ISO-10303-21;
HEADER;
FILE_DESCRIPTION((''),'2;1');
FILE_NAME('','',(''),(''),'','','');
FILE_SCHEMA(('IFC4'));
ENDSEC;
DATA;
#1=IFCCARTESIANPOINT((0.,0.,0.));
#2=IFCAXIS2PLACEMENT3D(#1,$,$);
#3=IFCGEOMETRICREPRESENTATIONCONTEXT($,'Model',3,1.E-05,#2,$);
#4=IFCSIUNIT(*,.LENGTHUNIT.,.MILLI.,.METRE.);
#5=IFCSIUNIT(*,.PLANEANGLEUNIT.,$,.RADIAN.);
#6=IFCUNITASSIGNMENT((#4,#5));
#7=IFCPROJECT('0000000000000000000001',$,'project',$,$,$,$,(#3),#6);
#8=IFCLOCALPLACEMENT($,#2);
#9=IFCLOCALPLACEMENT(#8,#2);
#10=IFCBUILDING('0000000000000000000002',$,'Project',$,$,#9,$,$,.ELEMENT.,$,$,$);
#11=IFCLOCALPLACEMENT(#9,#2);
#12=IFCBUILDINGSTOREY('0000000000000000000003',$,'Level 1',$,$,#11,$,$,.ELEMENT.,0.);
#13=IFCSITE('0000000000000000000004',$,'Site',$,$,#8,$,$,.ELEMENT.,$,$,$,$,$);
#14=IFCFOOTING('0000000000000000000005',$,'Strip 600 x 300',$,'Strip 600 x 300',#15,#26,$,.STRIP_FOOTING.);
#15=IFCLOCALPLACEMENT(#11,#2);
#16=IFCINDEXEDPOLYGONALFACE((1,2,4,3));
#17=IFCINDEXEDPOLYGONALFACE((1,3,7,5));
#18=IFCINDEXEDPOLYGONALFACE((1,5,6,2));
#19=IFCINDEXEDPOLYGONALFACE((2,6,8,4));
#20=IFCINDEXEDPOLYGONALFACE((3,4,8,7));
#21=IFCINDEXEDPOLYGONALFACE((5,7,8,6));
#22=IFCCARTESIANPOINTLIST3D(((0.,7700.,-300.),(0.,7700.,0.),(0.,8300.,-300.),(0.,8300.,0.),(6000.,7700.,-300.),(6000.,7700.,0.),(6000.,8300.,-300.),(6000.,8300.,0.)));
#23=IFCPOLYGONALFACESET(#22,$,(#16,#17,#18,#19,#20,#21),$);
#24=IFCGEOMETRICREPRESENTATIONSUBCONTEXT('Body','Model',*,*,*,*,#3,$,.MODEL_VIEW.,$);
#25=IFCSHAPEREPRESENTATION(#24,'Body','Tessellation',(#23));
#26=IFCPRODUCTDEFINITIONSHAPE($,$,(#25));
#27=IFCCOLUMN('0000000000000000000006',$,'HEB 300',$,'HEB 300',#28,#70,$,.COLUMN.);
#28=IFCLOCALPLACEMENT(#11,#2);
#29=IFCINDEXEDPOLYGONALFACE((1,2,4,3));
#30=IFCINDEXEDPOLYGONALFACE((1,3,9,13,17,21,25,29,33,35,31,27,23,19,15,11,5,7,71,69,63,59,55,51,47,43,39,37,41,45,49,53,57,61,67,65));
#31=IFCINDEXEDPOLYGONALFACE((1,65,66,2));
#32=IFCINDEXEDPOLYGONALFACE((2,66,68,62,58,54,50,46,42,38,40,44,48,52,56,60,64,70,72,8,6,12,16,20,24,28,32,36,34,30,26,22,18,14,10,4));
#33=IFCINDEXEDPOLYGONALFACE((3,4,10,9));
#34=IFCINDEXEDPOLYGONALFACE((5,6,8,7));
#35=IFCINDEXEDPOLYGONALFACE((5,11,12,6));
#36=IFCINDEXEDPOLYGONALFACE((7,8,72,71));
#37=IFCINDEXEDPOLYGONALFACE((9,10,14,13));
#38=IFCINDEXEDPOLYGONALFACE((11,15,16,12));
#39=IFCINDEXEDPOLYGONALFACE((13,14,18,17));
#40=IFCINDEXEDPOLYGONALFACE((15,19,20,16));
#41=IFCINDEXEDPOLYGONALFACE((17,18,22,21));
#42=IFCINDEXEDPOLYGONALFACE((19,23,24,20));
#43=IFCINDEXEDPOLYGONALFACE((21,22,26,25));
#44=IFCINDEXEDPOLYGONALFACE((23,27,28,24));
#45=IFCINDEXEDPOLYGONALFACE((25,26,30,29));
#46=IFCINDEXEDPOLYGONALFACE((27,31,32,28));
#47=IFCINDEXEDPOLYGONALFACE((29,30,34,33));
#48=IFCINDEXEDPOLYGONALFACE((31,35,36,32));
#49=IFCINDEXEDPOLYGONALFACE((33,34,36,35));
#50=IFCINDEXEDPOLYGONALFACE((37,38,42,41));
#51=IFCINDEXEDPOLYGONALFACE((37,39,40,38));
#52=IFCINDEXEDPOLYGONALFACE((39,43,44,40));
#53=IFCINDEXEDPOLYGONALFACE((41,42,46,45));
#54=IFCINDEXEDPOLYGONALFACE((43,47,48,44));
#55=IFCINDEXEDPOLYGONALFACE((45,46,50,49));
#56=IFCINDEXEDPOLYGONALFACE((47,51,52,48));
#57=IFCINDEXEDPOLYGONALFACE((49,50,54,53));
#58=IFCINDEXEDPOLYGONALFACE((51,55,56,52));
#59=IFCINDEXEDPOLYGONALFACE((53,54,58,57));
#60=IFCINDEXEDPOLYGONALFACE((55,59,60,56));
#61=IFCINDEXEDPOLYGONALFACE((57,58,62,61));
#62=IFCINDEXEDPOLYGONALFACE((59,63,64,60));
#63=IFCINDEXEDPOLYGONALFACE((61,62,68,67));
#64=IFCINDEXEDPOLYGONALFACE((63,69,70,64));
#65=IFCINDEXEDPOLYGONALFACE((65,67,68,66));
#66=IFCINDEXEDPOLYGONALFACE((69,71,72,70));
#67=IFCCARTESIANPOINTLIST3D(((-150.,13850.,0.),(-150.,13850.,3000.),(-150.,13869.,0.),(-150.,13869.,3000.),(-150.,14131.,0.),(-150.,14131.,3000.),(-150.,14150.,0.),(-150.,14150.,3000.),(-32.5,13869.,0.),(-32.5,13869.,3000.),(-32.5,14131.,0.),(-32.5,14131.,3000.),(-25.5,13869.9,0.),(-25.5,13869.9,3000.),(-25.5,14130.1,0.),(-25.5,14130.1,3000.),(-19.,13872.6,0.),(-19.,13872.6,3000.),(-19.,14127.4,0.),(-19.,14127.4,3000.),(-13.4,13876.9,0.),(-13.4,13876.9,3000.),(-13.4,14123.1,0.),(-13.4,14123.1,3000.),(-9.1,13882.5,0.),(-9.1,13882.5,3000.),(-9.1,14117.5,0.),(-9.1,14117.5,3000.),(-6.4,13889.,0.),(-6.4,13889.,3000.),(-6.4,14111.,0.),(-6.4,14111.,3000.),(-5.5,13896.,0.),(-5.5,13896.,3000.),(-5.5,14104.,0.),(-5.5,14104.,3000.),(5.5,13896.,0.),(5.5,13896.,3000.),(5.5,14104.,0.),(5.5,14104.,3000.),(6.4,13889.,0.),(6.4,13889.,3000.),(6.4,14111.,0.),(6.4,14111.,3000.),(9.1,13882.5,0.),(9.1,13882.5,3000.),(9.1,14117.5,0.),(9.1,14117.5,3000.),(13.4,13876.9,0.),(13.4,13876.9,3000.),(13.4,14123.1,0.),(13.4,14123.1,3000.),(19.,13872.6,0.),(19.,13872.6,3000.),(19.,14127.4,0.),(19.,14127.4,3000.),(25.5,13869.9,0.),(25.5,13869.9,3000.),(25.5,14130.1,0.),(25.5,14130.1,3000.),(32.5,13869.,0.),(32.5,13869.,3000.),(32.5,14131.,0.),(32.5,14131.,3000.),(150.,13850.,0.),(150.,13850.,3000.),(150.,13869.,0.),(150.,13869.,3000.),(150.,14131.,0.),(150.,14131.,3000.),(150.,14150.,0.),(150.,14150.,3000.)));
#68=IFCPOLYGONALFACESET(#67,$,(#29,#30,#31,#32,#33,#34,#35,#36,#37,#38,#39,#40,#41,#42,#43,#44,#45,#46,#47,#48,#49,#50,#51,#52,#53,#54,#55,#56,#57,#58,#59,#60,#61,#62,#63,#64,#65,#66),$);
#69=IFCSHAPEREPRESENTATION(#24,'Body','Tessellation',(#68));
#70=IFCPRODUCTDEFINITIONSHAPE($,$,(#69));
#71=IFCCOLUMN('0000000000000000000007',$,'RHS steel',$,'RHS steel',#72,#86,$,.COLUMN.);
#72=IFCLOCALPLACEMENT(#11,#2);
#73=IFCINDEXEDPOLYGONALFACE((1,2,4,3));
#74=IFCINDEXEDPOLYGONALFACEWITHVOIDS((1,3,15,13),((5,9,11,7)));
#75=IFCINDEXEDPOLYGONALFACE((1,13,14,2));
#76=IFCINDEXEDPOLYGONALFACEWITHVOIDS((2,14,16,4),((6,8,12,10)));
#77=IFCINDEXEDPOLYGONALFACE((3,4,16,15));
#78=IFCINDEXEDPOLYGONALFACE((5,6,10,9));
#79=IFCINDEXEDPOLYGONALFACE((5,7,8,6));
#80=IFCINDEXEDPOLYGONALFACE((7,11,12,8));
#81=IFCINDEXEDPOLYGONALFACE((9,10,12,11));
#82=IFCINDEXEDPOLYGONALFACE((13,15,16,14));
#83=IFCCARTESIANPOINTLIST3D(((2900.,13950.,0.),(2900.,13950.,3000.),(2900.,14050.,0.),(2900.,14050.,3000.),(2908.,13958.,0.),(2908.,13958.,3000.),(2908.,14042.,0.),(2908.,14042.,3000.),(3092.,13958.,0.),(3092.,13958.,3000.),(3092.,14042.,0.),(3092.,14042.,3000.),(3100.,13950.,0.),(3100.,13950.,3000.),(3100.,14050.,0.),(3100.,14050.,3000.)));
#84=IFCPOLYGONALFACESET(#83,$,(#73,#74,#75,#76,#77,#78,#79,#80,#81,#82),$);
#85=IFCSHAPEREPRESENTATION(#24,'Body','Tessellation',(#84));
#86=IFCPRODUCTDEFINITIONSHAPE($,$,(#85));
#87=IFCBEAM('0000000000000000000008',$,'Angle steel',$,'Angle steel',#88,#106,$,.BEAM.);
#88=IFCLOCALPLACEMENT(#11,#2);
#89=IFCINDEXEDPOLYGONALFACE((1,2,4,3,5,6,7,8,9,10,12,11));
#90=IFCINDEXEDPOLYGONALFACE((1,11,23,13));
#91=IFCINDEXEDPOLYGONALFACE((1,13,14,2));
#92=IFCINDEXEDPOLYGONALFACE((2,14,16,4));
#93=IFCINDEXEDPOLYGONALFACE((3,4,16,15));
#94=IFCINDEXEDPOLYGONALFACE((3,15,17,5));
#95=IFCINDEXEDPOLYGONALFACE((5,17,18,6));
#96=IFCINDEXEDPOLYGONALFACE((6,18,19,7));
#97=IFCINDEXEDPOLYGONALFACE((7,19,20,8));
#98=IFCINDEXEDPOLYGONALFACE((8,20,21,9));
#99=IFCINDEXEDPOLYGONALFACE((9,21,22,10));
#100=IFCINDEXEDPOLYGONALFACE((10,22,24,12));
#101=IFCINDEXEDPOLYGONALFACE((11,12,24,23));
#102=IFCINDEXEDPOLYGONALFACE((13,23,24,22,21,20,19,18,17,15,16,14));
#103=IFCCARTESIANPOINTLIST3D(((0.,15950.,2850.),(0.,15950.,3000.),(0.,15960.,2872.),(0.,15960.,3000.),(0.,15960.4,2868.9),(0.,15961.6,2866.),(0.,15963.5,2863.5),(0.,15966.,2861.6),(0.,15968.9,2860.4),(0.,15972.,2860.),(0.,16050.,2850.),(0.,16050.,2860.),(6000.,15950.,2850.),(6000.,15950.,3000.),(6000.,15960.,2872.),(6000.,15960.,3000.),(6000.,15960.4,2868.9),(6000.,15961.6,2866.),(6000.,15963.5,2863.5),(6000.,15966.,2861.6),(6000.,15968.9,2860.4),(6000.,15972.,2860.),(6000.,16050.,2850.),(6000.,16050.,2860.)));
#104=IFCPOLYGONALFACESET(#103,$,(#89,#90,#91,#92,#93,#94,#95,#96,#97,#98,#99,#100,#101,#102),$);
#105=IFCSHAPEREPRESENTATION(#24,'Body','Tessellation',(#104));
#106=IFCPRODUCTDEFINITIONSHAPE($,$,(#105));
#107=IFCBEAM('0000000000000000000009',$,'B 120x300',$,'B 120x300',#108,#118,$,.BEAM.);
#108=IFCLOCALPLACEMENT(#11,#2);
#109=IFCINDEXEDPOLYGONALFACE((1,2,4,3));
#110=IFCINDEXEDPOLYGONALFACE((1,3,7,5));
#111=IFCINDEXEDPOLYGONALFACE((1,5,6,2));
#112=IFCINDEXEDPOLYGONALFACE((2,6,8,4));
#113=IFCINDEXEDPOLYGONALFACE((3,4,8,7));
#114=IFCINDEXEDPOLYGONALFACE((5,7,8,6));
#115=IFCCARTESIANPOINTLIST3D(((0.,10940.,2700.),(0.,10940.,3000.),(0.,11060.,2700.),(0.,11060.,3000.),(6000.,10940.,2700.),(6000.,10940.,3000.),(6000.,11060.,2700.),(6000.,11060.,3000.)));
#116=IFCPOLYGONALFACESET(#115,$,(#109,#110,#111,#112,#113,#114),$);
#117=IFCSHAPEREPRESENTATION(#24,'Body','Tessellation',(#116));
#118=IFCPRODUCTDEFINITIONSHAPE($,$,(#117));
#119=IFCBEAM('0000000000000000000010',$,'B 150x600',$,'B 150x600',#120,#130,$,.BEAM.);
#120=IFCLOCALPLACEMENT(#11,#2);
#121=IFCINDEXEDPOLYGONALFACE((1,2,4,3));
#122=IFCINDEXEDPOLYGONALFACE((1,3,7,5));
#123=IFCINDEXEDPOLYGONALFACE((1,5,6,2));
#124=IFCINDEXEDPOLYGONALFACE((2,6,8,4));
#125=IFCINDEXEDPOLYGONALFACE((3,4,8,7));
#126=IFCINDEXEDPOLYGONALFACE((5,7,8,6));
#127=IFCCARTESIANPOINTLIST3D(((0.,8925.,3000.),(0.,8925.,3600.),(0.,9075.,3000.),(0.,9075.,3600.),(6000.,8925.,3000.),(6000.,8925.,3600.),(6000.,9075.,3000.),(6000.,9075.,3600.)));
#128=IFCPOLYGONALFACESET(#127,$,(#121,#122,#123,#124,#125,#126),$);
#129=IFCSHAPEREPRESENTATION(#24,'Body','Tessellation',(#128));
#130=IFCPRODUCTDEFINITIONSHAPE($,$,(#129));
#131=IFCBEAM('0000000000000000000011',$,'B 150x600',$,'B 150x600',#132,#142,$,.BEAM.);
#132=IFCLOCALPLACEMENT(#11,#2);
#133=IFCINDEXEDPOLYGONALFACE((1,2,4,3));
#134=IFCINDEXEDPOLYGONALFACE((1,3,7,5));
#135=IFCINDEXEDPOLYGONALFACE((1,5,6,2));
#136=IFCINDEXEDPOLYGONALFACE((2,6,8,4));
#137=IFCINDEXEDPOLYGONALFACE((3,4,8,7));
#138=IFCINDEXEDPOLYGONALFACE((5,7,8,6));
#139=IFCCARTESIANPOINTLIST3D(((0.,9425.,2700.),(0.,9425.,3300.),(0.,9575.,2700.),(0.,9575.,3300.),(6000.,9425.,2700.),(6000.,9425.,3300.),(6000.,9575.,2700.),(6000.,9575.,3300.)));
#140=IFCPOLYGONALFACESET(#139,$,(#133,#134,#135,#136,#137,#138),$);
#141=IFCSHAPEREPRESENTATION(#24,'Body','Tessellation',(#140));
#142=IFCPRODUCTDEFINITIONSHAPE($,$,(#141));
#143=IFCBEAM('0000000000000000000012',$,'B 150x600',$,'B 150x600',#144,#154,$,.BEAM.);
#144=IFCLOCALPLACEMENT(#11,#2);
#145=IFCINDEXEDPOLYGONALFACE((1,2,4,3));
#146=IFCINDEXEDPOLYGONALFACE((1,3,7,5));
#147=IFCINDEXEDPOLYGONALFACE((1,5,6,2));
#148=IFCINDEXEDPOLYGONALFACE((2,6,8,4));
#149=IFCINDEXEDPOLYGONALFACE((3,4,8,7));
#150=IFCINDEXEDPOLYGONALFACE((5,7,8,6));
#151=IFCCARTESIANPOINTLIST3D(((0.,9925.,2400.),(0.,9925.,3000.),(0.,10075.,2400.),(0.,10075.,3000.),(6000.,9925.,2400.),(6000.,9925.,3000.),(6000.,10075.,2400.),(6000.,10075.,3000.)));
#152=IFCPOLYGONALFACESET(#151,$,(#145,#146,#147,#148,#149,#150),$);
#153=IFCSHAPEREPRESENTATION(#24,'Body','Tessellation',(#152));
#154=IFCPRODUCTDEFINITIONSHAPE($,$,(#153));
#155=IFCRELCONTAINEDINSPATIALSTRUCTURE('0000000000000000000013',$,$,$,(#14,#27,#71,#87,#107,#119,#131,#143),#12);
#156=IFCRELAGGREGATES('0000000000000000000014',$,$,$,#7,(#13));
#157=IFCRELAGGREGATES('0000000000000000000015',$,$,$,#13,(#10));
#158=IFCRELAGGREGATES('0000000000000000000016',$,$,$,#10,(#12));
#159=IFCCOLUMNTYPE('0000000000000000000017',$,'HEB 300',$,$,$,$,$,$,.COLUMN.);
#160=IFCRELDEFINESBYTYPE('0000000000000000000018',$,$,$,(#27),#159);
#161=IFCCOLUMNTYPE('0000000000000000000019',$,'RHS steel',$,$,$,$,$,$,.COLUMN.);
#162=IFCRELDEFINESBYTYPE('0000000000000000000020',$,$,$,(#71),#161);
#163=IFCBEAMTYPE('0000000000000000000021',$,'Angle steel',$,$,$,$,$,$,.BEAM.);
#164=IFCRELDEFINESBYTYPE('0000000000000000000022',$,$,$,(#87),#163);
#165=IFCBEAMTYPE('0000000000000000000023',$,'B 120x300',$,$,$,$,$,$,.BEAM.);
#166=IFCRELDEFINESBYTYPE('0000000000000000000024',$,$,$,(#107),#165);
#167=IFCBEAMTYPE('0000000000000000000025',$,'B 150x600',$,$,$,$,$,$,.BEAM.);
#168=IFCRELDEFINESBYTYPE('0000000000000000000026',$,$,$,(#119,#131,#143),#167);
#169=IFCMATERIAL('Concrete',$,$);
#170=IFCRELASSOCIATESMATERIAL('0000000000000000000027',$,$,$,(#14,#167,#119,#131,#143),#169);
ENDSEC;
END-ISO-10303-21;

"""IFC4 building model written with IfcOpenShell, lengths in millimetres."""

from ifc_helpers import new_model, si_unit, frame, origin, origin_2d, place, context, subcontext, project, spatial, rectangle, hollow_rectangle, i_section, l_section, extrude, material, material_profile, profile_set, profile_usage, type_object, element, save


model = new_model("IFC4")

# Units and contexts
model_context = context("Model", 3, precision=1e-05, world=origin())
body_context = subcontext(model_context, "Body", "Model", "MODEL_VIEW")
ifc_project = project(units=[si_unit("LENGTHUNIT", "METRE", prefix="MILLI"), si_unit("PLANEANGLEUNIT", "RADIAN")], contexts=[model_context])

# Site, building, storey
site_placement = place(None, origin())
site = spatial("IfcSite", under=ifc_project, at=site_placement, Name="Site", CompositionType="ELEMENT")
building_placement = place(site_placement, origin())
building = spatial("IfcBuilding", under=site, at=building_placement, Name="Project", CompositionType="ELEMENT")
storey_placement = place(building_placement, origin())
storey = spatial("IfcBuildingStorey", under=building, at=storey_placement, Name="Level 1", CompositionType="ELEMENT", Elevation=0.0)

# Footing
ifc_material_1 = material(Name="Concrete")
footing_placement = place(storey_placement, frame((0.0, 8000.0, -150.0)))
element("IfcFooting", 1, at=footing_placement, inside=storey, material=ifc_material_1, Name="Strip 600 x 300", ObjectType="Strip 600 x 300", PredefinedType="STRIP_FOOTING", context=body_context, shape_type="SweptSolid", body=[
    extrude(rectangle(XDim=600.0, YDim=300.0, at=origin_2d()), frame((0.0, 0.0, 0.0), z_axis=(1.0, 0.0, 0.0), x_axis=(0.0, 1.0, 0.0)), (0.0, 0.0, 1.0), 6000.0),
])

# Columns
ifc_material_profile_1 = material_profile(None, i_section(OverallWidth=300.0, OverallDepth=300.0, WebThickness=11.0, FlangeThickness=19.0, FilletRadius=27.0, at=origin_2d()), Name="HEB 300")
ifc_profile_set_1 = profile_set([ifc_material_profile_1], Name="HEB 300")
ifc_profile_usage_1 = profile_usage(ifc_profile_set_1, cardinal=5)
column_type_1 = type_object("IfcColumnType", Name="HEB 300", PredefinedType="COLUMN", material=ifc_profile_set_1)
column_1_placement = place(storey_placement, frame((0.0, 14000.0, 0.0), z_axis=(0.0, 0.0, 1.0), x_axis=(1.0, 0.0, 0.0)))
element("IfcColumn", 2, at=column_1_placement, inside=storey, type_object=column_type_1, material=ifc_profile_usage_1, Name="HEB 300", ObjectType="HEB 300", PredefinedType="COLUMN", context=body_context, shape_type="SweptSolid", body=[
    extrude(i_section(OverallWidth=300.0, OverallDepth=300.0, WebThickness=11.0, FlangeThickness=19.0, FilletRadius=27.0, at=origin_2d()), origin(), (0.0, 0.0, 1.0), 3000.0),
])
ifc_material_profile_2 = material_profile(None, hollow_rectangle(XDim=200.0, YDim=100.0, WallThickness=8.0, at=origin_2d()), Name="RHS steel")
ifc_profile_set_2 = profile_set([ifc_material_profile_2], Name="RHS steel")
ifc_profile_usage_2 = profile_usage(ifc_profile_set_2, cardinal=5)
column_type_2 = type_object("IfcColumnType", Name="RHS steel", PredefinedType="COLUMN", material=ifc_profile_set_2)
column_2_placement = place(storey_placement, frame((3000.0, 14000.0, 0.0), z_axis=(0.0, 0.0, 1.0), x_axis=(1.0, 0.0, 0.0)))
element("IfcColumn", 3, at=column_2_placement, inside=storey, type_object=column_type_2, material=ifc_profile_usage_2, Name="RHS steel", ObjectType="RHS steel", PredefinedType="COLUMN", context=body_context, shape_type="SweptSolid", body=[
    extrude(hollow_rectangle(XDim=200.0, YDim=100.0, WallThickness=8.0, at=origin_2d()), origin(), (0.0, 0.0, 1.0), 3000.0),
])

# Beams
ifc_material_profile_3 = material_profile(None, l_section(Depth=150.0, Width=100.0, Thickness=10.0, FilletRadius=12.0, at=origin_2d()), Name="Angle steel")
ifc_profile_set_3 = profile_set([ifc_material_profile_3], Name="Angle steel")
ifc_profile_usage_3 = profile_usage(ifc_profile_set_3, cardinal=8)
beam_type_1 = type_object("IfcBeamType", Name="Angle steel", PredefinedType="BEAM", material=ifc_profile_set_3)
beam_1_placement = place(storey_placement, frame((0.0, 16000.0, 2925.0)))
element("IfcBeam", 4, at=beam_1_placement, inside=storey, type_object=beam_type_1, material=ifc_profile_usage_3, Name="Angle steel", ObjectType="Angle steel", PredefinedType="BEAM", context=body_context, shape_type="SweptSolid", body=[
    extrude(l_section(Depth=150.0, Width=100.0, Thickness=10.0, FilletRadius=12.0, at=origin_2d()), frame((0.0, 0.0, 0.0), z_axis=(1.0, 0.0, 0.0), x_axis=(0.0, 1.0, 0.0)), (0.0, 0.0, 1.0), 6000.0),
])
ifc_material_profile_4 = material_profile(None, rectangle(XDim=120.0, YDim=300.0, at=origin_2d()), Name="B 120x300")
ifc_profile_set_4 = profile_set([ifc_material_profile_4], Name="B 120x300")
ifc_profile_usage_4 = profile_usage(ifc_profile_set_4, cardinal=8)
beam_type_2 = type_object("IfcBeamType", Name="B 120x300", PredefinedType="BEAM", material=ifc_profile_set_4)
beam_2_placement = place(storey_placement, frame((0.0, 11000.0, 2850.0)))
element("IfcBeam", 5, at=beam_2_placement, inside=storey, type_object=beam_type_2, material=ifc_profile_usage_4, Name="B 120x300", ObjectType="B 120x300", PredefinedType="BEAM", context=body_context, shape_type="SweptSolid", body=[
    extrude(rectangle(XDim=120.0, YDim=300.0, at=origin_2d()), frame((0.0, 0.0, 0.0), z_axis=(1.0, 0.0, 0.0), x_axis=(0.0, 1.0, 0.0)), (0.0, 0.0, 1.0), 6000.0),
])
ifc_material_profile_5 = material_profile(ifc_material_1, rectangle(XDim=150.0, YDim=600.0, at=origin_2d()), Name="B 150x600")
ifc_profile_set_5 = profile_set([ifc_material_profile_5], Name="B 150x600")
ifc_profile_usage_5 = profile_usage(ifc_profile_set_5, cardinal=2)
beam_type_3 = type_object("IfcBeamType", Name="B 150x600", PredefinedType="BEAM", material=ifc_profile_set_5)
beam_3_placement = place(storey_placement, frame((0.0, 9000.0, 3300.0)))
element("IfcBeam", 6, at=beam_3_placement, inside=storey, type_object=beam_type_3, material=ifc_profile_usage_5, Name="B 150x600", ObjectType="B 150x600", PredefinedType="BEAM", context=body_context, shape_type="SweptSolid", body=[
    extrude(rectangle(XDim=150.0, YDim=600.0, at=origin_2d()), frame((0.0, 0.0, 0.0), z_axis=(1.0, 0.0, 0.0), x_axis=(0.0, 1.0, 0.0)), (0.0, 0.0, 1.0), 6000.0),
])
ifc_profile_usage_6 = profile_usage(ifc_profile_set_5, cardinal=5)
beam_4_placement = place(storey_placement, frame((0.0, 9500.0, 3000.0)))
element("IfcBeam", 7, at=beam_4_placement, inside=storey, type_object=beam_type_3, material=ifc_profile_usage_6, Name="B 150x600", ObjectType="B 150x600", PredefinedType="BEAM", context=body_context, shape_type="SweptSolid", body=[
    extrude(rectangle(XDim=150.0, YDim=600.0, at=origin_2d()), frame((0.0, 0.0, 0.0), z_axis=(1.0, 0.0, 0.0), x_axis=(0.0, 1.0, 0.0)), (0.0, 0.0, 1.0), 6000.0),
])
ifc_profile_usage_7 = profile_usage(ifc_profile_set_5, cardinal=8)
beam_5_placement = place(storey_placement, frame((0.0, 10000.0, 2700.0)))
element("IfcBeam", 8, at=beam_5_placement, inside=storey, type_object=beam_type_3, material=ifc_profile_usage_7, Name="B 150x600", ObjectType="B 150x600", PredefinedType="BEAM", context=body_context, shape_type="SweptSolid", body=[
    extrude(rectangle(XDim=150.0, YDim=600.0, at=origin_2d()), frame((0.0, 0.0, 0.0), z_axis=(1.0, 0.0, 0.0), x_axis=(0.0, 1.0, 0.0)), (0.0, 0.0, 1.0), 6000.0),
])

save(model, "model.ifc")
